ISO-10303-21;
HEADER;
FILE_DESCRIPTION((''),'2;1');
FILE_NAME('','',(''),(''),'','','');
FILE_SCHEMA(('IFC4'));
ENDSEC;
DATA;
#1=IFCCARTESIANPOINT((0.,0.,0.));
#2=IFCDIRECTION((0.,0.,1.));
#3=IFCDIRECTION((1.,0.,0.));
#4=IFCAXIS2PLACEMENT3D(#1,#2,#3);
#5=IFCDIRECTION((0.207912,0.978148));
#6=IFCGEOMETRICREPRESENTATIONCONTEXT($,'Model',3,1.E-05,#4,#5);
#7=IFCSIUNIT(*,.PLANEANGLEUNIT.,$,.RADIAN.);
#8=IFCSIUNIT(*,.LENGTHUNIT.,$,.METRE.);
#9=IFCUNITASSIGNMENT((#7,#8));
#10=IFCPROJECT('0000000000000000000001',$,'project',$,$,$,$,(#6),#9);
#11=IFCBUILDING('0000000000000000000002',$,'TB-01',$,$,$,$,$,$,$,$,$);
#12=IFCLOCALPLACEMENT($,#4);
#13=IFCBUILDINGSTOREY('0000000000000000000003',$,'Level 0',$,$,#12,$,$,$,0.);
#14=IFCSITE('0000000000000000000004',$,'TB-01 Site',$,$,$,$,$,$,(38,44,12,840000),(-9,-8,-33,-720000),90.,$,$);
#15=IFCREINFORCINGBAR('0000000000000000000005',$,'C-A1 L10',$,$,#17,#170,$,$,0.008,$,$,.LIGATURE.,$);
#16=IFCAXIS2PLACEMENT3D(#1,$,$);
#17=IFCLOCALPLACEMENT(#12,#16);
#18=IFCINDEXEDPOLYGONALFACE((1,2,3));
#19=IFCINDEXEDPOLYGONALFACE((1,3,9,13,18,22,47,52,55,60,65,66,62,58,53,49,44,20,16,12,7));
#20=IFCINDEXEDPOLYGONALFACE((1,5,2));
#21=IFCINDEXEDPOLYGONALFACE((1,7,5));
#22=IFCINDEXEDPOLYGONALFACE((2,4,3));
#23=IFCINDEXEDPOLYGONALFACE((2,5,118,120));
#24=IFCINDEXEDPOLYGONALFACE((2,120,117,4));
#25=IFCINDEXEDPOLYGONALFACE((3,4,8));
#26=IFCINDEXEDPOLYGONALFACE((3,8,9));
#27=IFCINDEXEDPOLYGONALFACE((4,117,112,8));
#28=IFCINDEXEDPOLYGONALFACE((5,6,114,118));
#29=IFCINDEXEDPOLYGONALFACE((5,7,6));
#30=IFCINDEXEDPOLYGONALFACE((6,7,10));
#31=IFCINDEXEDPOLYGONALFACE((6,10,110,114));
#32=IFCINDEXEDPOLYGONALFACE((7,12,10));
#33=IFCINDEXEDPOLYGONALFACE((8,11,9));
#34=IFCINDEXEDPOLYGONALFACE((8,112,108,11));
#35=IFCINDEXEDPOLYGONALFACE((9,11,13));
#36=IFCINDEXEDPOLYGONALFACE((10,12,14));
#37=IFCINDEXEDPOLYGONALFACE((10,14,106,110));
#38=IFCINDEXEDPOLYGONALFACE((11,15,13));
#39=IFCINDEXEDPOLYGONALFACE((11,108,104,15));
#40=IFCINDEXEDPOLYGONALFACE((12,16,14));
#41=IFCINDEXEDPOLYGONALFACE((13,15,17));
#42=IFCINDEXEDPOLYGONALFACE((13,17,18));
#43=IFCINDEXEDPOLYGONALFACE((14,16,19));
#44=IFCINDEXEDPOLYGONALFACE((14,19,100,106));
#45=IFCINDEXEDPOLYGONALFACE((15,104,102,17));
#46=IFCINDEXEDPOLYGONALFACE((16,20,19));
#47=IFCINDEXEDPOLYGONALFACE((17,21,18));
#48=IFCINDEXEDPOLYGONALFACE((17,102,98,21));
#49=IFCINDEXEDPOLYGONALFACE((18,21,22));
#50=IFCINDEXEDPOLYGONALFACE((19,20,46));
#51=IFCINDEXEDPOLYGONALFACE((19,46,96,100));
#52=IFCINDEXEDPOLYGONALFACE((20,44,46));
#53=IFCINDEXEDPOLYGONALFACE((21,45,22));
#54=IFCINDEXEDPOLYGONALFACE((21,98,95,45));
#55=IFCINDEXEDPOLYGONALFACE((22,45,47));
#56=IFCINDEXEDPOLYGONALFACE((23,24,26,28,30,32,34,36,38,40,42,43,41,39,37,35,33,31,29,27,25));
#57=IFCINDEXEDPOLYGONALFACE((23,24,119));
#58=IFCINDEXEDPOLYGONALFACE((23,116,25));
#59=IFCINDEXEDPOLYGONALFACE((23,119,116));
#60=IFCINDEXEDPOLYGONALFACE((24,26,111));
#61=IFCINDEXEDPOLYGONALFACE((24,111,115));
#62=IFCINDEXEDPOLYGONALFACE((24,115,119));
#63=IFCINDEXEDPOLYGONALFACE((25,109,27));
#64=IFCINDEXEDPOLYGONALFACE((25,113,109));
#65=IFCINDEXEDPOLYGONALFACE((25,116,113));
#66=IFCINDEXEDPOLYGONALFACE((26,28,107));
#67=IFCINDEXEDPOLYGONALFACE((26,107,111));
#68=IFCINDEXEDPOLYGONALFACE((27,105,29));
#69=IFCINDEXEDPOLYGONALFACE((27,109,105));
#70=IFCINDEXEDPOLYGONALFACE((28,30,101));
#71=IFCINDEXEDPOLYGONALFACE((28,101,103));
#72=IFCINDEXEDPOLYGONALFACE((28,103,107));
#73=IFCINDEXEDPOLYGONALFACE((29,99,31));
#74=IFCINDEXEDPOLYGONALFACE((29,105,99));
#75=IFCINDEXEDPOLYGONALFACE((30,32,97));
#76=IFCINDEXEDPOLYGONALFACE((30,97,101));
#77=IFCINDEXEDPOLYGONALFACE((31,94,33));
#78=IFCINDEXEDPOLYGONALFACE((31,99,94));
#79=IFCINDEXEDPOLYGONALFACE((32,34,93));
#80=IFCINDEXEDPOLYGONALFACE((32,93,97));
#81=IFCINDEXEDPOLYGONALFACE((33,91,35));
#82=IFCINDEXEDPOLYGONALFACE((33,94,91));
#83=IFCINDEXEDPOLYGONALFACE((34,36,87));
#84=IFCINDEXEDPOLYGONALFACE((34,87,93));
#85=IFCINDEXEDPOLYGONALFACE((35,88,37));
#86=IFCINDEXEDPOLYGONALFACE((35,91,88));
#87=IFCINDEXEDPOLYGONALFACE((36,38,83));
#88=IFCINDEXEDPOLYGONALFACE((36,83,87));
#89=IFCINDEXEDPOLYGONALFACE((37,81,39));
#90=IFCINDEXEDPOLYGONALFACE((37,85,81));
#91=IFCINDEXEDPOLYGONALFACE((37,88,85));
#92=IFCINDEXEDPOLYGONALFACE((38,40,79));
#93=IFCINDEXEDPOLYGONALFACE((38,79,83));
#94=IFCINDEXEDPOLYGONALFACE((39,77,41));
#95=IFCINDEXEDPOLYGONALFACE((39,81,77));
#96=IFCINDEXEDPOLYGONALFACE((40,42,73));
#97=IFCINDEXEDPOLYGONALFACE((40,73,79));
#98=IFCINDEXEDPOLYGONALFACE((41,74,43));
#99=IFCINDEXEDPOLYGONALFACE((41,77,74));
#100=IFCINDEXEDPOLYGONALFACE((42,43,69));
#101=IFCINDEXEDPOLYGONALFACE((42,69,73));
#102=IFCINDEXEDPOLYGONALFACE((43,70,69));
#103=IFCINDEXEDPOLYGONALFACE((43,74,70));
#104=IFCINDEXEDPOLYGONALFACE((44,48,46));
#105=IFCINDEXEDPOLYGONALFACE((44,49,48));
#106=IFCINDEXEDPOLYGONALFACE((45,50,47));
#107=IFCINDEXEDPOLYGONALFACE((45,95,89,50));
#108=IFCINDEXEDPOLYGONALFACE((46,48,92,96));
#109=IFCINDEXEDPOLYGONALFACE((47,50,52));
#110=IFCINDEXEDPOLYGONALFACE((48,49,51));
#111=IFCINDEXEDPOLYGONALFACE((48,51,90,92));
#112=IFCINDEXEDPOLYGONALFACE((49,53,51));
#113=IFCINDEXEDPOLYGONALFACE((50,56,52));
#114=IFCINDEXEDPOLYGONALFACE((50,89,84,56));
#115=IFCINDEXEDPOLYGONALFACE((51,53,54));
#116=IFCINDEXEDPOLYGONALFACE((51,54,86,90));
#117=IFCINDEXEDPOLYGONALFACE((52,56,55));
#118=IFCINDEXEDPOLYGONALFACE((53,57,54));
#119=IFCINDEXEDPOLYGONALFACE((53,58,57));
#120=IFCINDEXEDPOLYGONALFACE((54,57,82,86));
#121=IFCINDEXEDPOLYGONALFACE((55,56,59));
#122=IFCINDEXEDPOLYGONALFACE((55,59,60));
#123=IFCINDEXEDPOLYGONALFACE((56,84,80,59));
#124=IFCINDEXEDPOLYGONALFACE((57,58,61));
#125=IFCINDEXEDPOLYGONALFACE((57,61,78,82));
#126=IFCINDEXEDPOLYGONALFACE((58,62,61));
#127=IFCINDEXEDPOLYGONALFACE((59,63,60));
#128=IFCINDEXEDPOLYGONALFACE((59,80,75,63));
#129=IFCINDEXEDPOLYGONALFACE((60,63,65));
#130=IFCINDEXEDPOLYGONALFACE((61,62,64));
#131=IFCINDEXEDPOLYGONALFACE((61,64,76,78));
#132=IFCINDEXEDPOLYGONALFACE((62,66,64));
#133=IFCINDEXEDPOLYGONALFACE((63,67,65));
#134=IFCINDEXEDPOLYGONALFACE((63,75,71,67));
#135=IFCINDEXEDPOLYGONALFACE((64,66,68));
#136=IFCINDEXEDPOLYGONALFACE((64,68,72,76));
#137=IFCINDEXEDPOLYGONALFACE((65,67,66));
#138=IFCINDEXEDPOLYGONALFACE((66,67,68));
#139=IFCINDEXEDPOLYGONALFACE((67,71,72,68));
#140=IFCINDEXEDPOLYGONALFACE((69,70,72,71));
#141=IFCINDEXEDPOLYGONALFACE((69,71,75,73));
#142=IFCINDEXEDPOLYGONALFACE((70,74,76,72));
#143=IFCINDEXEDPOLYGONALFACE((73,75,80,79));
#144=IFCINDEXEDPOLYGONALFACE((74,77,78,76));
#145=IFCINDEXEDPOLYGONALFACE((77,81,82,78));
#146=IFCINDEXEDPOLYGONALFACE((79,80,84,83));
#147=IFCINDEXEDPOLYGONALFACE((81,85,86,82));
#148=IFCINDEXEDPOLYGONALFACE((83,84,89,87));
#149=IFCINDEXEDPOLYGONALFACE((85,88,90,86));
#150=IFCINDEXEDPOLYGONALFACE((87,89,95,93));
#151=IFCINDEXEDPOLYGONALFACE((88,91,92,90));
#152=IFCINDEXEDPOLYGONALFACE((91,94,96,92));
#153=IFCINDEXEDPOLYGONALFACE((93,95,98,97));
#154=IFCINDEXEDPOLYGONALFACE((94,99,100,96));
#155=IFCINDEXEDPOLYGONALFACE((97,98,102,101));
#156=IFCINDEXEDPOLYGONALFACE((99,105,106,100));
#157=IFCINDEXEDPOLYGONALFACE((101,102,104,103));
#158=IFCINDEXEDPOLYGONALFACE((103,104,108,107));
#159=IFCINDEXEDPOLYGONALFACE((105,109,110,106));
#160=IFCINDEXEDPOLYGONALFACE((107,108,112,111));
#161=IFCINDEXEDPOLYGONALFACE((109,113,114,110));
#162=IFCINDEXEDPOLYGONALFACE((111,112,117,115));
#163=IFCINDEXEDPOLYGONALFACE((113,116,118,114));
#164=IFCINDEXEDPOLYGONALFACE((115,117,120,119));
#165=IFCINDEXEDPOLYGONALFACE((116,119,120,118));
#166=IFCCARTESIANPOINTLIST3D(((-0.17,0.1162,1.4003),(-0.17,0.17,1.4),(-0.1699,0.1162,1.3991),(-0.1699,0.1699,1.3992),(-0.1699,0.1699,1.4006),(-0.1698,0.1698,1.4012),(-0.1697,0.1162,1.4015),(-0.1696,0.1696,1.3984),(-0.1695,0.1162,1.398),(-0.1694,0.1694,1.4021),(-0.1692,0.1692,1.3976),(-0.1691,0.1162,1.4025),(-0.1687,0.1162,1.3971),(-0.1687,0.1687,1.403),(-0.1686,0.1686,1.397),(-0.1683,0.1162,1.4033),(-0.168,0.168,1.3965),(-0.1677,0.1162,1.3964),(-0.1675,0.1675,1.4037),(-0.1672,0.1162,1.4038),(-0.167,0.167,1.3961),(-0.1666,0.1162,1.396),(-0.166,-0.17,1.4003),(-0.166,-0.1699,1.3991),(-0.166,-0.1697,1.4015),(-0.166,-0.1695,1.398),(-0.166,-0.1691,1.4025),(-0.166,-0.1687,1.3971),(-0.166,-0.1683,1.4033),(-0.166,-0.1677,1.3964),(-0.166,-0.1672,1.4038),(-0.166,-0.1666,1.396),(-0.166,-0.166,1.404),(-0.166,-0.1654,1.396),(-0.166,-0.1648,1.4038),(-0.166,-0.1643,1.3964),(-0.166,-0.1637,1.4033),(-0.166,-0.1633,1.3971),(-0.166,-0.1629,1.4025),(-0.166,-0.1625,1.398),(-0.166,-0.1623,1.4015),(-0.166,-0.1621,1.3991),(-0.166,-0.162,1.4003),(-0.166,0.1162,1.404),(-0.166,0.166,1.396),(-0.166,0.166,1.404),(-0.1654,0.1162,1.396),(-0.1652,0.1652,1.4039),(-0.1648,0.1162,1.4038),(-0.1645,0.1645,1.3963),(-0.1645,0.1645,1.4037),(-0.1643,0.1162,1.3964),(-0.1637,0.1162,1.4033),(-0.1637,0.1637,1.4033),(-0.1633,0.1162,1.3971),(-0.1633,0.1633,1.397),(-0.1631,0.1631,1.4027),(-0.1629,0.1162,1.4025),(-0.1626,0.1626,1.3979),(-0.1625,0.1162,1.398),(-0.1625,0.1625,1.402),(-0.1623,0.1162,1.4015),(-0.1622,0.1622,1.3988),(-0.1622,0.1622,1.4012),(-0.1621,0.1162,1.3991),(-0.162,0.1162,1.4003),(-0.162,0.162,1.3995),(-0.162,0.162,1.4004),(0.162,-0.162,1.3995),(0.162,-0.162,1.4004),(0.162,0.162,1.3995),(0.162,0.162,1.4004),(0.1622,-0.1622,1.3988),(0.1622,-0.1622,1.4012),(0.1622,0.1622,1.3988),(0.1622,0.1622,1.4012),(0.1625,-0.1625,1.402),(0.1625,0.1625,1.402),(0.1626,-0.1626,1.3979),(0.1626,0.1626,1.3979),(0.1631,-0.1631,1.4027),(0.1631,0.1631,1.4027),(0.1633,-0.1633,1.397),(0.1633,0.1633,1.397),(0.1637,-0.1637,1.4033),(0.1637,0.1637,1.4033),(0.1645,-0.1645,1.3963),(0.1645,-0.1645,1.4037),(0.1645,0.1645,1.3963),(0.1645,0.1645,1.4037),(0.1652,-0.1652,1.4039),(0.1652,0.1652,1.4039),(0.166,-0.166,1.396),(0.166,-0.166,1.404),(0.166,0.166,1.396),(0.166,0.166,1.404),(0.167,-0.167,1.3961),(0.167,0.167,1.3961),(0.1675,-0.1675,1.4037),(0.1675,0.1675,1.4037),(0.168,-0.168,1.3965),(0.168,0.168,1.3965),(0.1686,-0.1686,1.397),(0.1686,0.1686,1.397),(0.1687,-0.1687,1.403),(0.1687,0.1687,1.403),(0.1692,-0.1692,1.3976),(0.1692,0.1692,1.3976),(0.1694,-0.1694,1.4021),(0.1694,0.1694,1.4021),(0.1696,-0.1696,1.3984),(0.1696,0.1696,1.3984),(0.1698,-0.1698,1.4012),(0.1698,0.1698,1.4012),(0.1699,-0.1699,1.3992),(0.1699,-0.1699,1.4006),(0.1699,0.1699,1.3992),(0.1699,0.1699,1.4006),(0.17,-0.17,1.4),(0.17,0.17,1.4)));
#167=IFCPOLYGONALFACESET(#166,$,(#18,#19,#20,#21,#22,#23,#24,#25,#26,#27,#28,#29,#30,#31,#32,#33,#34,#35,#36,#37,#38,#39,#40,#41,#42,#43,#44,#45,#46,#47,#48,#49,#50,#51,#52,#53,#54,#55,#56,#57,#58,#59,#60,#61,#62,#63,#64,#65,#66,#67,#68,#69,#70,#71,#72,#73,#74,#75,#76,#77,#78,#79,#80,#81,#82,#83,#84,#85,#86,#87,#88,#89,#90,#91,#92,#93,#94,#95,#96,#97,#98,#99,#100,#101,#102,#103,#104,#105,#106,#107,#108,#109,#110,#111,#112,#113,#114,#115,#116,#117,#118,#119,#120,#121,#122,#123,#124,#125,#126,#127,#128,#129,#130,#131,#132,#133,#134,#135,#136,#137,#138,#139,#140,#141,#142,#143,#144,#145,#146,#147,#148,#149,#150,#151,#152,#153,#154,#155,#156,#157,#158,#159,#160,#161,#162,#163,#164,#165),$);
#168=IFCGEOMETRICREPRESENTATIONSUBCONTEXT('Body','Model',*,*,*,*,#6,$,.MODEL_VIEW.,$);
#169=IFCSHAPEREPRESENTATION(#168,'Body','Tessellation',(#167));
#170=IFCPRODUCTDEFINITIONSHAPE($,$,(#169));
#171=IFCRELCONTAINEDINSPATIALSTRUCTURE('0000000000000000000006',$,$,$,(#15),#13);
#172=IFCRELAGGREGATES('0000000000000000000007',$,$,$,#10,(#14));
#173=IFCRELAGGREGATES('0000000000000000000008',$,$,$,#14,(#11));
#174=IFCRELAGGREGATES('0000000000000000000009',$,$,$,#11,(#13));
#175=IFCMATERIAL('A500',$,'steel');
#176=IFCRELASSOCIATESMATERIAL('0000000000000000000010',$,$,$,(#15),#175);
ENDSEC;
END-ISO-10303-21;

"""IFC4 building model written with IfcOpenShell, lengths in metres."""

from ifc_helpers import new_model, entity, si_unit, direction, origin_with_axes, place, context, subcontext, project, spatial, material, element, save


model = new_model("IFC4")

# Units and contexts
model_context = context("Model", 3, precision=1e-05, world=origin_with_axes(), true_north=direction((0.207912, 0.978148)))
body_context = subcontext(model_context, "Body", "Model", "MODEL_VIEW")
ifc_project = project(units=[si_unit("PLANEANGLEUNIT", "RADIAN"), si_unit("LENGTHUNIT", "METRE")], contexts=[model_context])

# Site, building, storey
site = spatial("IfcSite", under=ifc_project, Name="TB-01 Site", RefLatitude=(38, 44, 12, 840000), RefLongitude=(-9, -8, -33, -720000), RefElevation=90.0)
building = spatial("IfcBuilding", under=site, Name="TB-01")
storey_placement = place(None, origin_with_axes())
storey = spatial("IfcBuildingStorey", under=building, at=storey_placement, Name="Level 0", Elevation=0.0)

# Reinforcing bar
ifc_material_1 = material(Name="A500", Category="steel")
reinforcing_bar_1_placement = place(storey_placement, origin_with_axes())
element("IfcReinforcingBar", 1, at=reinforcing_bar_1_placement, inside=storey, material=ifc_material_1, Name="C-A1 L10", NominalDiameter=0.008, PredefinedType="LIGATURE", context=body_context, shape_type="AdvancedSweptSolid", body=[
    entity("IfcSweptDiskSolid", entity("IfcPolyline", [entity("IfcCartesianPoint", [-0.166, -0.166, 1.4]), entity("IfcCartesianPoint", [0.166, -0.166, 1.4]), entity("IfcCartesianPoint", [0.166, 0.166, 1.4]), entity("IfcCartesianPoint", [-0.166, 0.166, 1.4]), entity("IfcCartesianPoint", [-0.166, 0.1162, 1.4])]), 0.004),
])

save(model, "model.ifc")
